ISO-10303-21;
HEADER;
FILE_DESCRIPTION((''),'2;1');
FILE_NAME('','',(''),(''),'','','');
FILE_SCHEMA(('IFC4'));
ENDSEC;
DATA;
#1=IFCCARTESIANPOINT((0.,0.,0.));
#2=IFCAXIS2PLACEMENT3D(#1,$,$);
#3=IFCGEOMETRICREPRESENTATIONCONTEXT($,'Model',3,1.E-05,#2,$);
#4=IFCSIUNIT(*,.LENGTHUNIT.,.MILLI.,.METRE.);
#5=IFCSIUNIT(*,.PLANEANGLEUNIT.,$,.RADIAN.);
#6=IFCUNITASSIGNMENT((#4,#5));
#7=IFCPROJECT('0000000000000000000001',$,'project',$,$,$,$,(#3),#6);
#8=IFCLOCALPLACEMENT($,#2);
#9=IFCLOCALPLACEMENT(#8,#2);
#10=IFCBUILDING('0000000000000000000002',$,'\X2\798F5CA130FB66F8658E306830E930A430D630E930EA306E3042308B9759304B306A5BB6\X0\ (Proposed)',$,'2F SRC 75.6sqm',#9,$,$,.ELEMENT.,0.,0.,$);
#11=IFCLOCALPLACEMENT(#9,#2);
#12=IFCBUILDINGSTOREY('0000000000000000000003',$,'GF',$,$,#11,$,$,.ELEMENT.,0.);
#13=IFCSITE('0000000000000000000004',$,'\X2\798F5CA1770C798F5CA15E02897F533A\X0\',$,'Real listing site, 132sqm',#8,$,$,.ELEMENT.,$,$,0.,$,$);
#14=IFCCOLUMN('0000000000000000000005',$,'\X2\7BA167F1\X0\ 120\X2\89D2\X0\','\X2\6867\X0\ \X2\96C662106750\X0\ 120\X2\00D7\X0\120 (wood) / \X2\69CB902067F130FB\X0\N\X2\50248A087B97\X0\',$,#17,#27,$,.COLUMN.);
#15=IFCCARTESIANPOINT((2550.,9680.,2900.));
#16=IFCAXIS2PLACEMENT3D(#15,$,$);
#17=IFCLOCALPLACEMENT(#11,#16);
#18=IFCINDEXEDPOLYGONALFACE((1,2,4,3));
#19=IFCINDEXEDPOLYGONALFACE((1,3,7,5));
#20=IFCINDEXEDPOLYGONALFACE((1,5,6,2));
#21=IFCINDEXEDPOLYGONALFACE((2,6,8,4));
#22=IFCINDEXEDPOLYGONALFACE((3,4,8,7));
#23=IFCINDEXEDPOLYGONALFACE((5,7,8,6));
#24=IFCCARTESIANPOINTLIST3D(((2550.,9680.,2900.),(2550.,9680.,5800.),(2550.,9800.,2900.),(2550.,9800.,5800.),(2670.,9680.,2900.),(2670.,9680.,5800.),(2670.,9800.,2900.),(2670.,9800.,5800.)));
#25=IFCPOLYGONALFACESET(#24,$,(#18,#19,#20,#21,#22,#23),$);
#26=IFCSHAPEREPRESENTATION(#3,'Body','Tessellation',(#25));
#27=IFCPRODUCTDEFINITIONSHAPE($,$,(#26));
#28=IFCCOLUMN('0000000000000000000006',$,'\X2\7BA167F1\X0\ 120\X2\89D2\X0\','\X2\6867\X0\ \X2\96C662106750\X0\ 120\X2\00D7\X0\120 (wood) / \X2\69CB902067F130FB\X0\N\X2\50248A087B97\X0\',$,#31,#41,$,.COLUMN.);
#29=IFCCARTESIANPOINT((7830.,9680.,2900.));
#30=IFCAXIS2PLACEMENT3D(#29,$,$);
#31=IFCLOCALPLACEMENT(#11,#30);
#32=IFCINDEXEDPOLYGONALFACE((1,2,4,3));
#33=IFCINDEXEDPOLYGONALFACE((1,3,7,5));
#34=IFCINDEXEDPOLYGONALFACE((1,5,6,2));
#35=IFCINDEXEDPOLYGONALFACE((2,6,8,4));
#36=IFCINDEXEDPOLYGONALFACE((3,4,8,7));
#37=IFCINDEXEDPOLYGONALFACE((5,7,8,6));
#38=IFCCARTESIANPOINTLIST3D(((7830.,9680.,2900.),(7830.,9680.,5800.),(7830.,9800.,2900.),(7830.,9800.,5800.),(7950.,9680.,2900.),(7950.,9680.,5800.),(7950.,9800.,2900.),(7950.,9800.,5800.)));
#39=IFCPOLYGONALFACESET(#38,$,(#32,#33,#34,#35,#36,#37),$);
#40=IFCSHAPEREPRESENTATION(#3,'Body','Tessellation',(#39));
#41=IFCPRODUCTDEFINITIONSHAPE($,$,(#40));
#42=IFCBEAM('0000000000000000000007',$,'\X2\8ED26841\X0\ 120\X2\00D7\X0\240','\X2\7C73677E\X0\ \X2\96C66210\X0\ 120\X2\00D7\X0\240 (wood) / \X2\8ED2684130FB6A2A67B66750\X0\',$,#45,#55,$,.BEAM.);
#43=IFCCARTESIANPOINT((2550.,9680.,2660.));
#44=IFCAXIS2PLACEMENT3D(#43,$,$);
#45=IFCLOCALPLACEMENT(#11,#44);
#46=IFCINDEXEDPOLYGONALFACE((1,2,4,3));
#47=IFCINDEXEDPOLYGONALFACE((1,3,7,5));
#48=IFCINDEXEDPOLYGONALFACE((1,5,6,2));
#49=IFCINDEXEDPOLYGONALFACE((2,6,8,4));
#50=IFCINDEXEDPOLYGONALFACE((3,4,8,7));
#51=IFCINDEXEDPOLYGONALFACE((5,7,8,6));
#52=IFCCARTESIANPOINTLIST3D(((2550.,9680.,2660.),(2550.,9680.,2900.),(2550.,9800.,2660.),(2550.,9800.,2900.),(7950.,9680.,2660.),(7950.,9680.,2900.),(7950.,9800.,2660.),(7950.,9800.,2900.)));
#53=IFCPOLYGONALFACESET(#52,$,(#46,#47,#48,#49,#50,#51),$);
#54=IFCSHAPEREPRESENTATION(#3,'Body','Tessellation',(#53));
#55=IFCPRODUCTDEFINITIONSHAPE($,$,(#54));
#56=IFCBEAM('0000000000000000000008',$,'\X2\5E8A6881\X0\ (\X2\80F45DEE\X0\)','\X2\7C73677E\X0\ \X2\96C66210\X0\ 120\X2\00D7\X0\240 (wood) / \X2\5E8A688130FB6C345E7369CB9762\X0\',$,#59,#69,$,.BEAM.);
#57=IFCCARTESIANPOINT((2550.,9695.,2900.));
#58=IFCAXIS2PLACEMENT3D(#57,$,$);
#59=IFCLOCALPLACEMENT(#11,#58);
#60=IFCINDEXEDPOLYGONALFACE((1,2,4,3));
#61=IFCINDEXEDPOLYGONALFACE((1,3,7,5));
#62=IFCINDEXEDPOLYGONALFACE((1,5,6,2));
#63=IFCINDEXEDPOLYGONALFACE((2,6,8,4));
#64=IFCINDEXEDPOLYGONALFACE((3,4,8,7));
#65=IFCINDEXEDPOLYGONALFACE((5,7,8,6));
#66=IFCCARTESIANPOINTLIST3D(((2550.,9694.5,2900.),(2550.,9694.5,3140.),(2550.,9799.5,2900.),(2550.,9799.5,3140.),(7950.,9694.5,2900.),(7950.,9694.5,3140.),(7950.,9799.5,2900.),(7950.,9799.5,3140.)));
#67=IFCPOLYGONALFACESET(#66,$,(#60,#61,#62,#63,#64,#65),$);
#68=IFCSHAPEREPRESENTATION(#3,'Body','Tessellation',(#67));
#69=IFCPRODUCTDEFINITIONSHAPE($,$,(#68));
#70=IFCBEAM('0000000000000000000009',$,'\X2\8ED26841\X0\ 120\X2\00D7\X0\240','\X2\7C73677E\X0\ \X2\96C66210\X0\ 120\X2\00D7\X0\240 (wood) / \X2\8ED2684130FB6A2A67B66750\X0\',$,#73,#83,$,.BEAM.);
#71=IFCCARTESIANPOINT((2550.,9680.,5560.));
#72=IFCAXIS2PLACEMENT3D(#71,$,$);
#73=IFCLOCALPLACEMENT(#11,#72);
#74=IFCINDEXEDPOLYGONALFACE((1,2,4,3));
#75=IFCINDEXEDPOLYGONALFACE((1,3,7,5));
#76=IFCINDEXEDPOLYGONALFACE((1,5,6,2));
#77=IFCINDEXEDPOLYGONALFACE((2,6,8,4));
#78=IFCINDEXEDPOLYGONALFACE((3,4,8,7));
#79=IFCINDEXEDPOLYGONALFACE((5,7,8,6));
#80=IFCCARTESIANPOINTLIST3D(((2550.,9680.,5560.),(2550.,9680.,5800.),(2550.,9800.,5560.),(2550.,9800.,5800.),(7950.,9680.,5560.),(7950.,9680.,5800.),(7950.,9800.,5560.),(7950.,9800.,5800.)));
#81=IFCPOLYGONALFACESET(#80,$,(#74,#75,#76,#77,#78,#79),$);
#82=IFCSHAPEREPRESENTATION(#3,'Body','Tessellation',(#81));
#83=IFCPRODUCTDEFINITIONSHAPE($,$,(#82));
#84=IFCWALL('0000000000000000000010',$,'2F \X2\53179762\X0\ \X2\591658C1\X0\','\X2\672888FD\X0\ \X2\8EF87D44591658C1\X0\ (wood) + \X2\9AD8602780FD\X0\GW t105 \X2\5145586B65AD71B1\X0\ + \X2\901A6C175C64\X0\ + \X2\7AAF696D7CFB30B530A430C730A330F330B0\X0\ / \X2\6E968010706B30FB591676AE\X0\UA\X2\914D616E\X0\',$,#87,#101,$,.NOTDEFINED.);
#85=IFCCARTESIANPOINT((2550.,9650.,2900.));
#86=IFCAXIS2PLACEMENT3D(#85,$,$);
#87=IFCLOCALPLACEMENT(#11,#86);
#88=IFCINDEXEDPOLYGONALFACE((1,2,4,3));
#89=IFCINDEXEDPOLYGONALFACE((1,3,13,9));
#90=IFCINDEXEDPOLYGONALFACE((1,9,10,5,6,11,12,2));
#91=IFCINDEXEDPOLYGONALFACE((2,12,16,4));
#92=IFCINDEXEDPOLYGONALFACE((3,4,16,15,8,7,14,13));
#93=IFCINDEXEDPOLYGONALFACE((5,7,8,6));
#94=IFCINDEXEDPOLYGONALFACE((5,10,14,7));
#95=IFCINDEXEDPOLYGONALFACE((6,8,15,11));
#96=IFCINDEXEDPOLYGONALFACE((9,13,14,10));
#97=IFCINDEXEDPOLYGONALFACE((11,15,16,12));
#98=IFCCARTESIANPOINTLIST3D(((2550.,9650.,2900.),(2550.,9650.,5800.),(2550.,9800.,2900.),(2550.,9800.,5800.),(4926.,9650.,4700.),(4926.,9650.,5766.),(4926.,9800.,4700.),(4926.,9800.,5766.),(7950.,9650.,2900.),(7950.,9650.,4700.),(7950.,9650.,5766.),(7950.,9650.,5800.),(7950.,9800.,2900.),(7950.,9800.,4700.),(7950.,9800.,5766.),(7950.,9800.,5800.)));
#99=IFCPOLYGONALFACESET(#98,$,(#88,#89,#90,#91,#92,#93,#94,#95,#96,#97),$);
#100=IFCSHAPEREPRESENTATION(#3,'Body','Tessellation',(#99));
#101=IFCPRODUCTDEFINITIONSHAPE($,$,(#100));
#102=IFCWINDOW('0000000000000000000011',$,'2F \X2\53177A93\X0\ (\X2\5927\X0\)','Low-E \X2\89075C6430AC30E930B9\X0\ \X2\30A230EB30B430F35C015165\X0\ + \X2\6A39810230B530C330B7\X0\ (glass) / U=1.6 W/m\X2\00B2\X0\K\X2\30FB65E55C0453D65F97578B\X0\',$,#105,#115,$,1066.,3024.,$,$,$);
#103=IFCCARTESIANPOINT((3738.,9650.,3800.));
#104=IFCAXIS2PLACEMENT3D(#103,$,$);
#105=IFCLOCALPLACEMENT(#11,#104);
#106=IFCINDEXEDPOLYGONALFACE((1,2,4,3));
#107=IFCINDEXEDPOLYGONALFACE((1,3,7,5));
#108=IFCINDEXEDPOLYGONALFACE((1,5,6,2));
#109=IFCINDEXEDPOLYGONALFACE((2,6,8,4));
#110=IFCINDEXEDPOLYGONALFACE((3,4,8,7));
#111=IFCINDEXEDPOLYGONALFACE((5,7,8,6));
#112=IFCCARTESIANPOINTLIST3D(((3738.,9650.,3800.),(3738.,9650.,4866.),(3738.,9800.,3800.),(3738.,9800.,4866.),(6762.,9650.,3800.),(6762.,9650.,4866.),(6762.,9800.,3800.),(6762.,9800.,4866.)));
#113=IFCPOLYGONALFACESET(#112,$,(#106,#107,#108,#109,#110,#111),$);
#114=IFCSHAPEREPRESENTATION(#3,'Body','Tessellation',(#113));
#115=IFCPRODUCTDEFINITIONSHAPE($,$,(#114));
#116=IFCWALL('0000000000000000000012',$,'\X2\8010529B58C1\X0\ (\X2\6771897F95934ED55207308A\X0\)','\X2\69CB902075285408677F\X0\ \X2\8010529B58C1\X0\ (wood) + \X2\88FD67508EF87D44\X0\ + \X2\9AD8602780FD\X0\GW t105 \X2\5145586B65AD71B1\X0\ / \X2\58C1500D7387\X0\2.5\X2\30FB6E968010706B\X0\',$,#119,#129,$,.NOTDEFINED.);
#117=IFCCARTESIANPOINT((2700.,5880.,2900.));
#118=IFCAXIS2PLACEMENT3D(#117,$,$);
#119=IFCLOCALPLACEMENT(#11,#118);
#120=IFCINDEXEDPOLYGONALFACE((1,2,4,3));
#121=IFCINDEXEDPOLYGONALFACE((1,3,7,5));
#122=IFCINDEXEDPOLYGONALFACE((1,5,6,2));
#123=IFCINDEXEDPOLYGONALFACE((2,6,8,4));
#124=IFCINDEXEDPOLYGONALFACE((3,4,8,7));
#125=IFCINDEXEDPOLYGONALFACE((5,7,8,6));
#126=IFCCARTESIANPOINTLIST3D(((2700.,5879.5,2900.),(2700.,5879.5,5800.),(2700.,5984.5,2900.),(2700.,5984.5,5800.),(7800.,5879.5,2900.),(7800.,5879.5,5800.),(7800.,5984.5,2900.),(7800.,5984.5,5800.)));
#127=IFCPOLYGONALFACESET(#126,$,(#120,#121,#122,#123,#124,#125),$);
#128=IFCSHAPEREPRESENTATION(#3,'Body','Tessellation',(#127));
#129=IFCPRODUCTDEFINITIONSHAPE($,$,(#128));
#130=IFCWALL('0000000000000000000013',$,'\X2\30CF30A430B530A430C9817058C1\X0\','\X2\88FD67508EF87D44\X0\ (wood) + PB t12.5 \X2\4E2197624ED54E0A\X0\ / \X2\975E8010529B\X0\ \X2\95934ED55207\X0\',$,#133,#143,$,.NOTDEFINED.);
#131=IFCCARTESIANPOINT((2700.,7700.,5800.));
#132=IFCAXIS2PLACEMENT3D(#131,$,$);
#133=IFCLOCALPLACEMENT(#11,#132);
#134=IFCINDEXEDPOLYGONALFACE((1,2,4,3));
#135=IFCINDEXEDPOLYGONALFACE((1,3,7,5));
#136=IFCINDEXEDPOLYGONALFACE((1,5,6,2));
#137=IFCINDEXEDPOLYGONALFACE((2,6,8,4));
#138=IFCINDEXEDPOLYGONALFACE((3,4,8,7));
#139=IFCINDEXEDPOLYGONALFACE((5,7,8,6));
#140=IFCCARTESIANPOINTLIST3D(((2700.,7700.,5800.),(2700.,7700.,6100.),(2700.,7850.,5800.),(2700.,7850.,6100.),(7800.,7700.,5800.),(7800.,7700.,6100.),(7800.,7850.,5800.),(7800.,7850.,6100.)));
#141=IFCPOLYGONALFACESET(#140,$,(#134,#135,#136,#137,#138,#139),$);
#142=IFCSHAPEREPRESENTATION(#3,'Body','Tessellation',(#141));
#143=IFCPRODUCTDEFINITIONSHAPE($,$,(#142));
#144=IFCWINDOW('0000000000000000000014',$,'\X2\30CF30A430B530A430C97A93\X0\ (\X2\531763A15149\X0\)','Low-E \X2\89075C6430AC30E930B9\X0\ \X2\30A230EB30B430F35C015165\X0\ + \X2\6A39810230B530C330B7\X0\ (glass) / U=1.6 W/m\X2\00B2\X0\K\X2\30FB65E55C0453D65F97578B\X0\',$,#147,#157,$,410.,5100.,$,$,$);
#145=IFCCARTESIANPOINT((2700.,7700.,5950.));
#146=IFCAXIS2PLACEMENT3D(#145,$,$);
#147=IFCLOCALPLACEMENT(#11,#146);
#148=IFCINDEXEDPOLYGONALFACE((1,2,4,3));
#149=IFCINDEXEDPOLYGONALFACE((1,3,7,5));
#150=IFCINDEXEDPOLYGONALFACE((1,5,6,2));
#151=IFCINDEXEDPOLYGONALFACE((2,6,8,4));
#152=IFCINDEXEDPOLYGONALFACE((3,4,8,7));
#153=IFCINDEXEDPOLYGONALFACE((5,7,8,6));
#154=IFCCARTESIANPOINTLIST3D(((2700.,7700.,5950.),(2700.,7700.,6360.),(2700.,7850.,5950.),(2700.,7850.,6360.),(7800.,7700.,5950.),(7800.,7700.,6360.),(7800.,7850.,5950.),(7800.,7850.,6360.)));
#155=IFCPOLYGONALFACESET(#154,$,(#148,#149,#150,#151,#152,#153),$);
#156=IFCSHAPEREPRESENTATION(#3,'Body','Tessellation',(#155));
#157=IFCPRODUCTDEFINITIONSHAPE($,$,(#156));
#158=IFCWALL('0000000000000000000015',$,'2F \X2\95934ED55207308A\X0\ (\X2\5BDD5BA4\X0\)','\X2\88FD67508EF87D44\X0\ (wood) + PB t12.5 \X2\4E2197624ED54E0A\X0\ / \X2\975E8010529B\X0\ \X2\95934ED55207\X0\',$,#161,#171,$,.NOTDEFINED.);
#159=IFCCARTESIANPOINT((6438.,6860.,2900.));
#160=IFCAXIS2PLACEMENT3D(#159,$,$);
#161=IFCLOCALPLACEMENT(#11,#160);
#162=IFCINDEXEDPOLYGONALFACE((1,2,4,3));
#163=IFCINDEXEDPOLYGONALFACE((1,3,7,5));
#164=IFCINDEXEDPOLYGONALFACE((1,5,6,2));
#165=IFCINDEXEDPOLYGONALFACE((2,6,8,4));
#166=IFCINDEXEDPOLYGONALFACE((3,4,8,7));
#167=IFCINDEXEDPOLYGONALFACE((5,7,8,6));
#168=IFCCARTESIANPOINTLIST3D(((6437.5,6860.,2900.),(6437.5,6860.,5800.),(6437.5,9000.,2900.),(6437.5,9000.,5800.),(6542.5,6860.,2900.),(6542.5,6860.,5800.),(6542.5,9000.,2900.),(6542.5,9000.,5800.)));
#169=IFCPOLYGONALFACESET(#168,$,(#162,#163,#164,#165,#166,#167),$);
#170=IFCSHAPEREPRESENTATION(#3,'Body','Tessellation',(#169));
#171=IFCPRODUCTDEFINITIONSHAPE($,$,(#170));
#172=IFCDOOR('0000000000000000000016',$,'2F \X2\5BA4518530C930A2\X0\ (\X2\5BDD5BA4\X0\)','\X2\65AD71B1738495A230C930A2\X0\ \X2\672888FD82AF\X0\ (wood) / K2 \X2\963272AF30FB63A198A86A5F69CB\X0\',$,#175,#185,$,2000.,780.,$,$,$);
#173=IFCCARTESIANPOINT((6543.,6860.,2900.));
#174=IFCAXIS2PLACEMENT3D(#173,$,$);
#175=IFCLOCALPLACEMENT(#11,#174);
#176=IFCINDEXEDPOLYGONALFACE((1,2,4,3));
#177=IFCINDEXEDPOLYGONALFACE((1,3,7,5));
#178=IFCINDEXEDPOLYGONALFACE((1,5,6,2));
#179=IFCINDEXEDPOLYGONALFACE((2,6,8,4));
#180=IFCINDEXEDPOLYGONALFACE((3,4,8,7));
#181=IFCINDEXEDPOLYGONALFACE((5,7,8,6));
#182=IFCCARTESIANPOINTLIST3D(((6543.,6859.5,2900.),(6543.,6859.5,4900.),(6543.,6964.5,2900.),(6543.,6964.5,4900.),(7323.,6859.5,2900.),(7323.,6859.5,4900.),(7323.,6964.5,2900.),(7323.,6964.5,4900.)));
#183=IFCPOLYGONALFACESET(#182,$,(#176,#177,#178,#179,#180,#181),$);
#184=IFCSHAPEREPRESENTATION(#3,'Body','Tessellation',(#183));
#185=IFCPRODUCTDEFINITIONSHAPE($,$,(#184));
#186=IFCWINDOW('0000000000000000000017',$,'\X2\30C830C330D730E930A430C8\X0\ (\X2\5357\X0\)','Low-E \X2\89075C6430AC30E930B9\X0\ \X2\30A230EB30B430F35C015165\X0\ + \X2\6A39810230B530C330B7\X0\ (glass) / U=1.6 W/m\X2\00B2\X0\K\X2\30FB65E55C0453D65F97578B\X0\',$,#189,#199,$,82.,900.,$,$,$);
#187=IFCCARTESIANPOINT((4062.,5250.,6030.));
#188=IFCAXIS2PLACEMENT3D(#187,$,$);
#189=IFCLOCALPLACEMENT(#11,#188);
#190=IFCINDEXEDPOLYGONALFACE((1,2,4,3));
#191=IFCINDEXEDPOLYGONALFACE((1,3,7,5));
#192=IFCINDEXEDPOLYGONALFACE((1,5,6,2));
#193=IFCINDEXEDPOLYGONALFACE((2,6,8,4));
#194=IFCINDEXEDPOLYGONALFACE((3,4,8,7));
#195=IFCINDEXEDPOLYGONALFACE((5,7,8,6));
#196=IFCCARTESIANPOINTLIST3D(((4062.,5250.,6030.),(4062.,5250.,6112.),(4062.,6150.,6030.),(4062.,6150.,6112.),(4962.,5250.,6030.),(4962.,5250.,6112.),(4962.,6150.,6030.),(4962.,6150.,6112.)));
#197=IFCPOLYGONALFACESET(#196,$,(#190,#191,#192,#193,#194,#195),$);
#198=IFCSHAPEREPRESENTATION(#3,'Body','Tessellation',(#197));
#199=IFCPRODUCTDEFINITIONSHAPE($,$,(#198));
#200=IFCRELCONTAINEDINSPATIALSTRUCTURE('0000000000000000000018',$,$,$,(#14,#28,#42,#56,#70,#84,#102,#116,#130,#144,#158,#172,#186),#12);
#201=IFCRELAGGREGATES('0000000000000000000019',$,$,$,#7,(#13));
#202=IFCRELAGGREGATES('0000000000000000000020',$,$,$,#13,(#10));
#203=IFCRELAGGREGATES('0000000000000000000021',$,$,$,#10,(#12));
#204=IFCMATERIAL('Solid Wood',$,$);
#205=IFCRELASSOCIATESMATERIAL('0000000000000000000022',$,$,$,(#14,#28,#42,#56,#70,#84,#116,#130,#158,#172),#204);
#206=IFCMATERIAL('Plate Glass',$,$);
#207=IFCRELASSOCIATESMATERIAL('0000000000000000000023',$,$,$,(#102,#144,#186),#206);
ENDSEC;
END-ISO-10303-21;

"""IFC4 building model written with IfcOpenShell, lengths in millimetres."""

from ifc_helpers import new_model, si_unit, frame, frame_2d, origin, place, context, project, spatial, rectangle, extrude, material, element, fill, save


model = new_model("IFC4")

# Units and contexts
model_context = context("Model", 3, precision=1e-05, world=origin())
ifc_project = project(units=[si_unit("LENGTHUNIT", "METRE", prefix="MILLI"), si_unit("PLANEANGLEUNIT", "RADIAN")], contexts=[model_context])

# Site, building, storey
site_placement = place(None, origin())
site = spatial("IfcSite", under=ifc_project, at=site_placement, Name="福岡県福岡市西区", ObjectType="Real listing site, 132sqm", CompositionType="ELEMENT", RefElevation=0.0)
building_placement = place(site_placement, origin())
building = spatial("IfcBuilding", under=site, at=building_placement, Name="福岡・書斎とライブラリのある静かな家 (Proposed)", ObjectType="2F SRC 75.6sqm", CompositionType="ELEMENT", ElevationOfRefHeight=0.0, ElevationOfTerrain=0.0)
storey_placement = place(building_placement, origin())
storey = spatial("IfcBuildingStorey", under=building, at=storey_placement, Name="GF", CompositionType="ELEMENT", Elevation=0.0)

# Columns
ifc_material_1 = material(Name="Solid Wood")
column_1_placement = place(storey_placement, frame((2550.0, 9680.0, 2900.0)))
element("IfcColumn", 1, at=column_1_placement, inside=storey, material=ifc_material_1, Name="管柱 120角", Description="桧 集成材 120×120 (wood) / 構造柱・N値計算", PredefinedType="COLUMN", context=model_context, shape_type="SweptSolid", body=[
    extrude(rectangle(XDim=120.0, YDim=120.0, at=frame_2d((60.0, 60.0))), frame((2550.0, 9680.0, 2900.0)), (0.0, 0.0, 1.0), 2900.0),
])
column_2_placement = place(storey_placement, frame((7830.0, 9680.0, 2900.0)))
element("IfcColumn", 2, at=column_2_placement, inside=storey, material=ifc_material_1, Name="管柱 120角", Description="桧 集成材 120×120 (wood) / 構造柱・N値計算", PredefinedType="COLUMN", context=model_context, shape_type="SweptSolid", body=[
    extrude(rectangle(XDim=120.0, YDim=120.0, at=frame_2d((60.0, 60.0))), frame((7830.0, 9680.0, 2900.0)), (0.0, 0.0, 1.0), 2900.0),
])

# Beams
beam_1_placement = place(storey_placement, frame((2550.0, 9680.0, 2660.0)))
element("IfcBeam", 3, at=beam_1_placement, inside=storey, material=ifc_material_1, Name="軒桁 120×240", Description="米松 集成 120×240 (wood) / 軒桁・横架材", PredefinedType="BEAM", context=model_context, shape_type="SweptSolid", body=[
    extrude(rectangle(XDim=5400.0, YDim=120.0, at=frame_2d((2700.0, 60.0))), frame((2550.0, 9680.0, 2660.0)), (0.0, 0.0, 1.0), 240.0),
])
beam_2_placement = place(storey_placement, frame((2550.0, 9695.0, 2900.0)))
element("IfcBeam", 4, at=beam_2_placement, inside=storey, material=ifc_material_1, Name="床梁 (胴差)", Description="米松 集成 120×240 (wood) / 床梁・水平構面", PredefinedType="BEAM", context=model_context, shape_type="SweptSolid", body=[
    extrude(rectangle(XDim=5400.0, YDim=105.0, at=frame_2d((2700.0, 52.0))), frame((2550.0, 9695.0, 2900.0)), (0.0, 0.0, 1.0), 240.0),
])
beam_3_placement = place(storey_placement, frame((2550.0, 9680.0, 5560.0)))
element("IfcBeam", 5, at=beam_3_placement, inside=storey, material=ifc_material_1, Name="軒桁 120×240", Description="米松 集成 120×240 (wood) / 軒桁・横架材", PredefinedType="BEAM", context=model_context, shape_type="SweptSolid", body=[
    extrude(rectangle(XDim=5400.0, YDim=120.0, at=frame_2d((2700.0, 60.0))), frame((2550.0, 9680.0, 5560.0)), (0.0, 0.0, 1.0), 240.0),
])

# Wall, opening, window
wall_1_placement = place(storey_placement, frame((2550.0, 9650.0, 2900.0)))
wall_1 = element("IfcWall", 6, at=wall_1_placement, inside=storey, material=ifc_material_1, Name="2F 北面 外壁", Description="木製 軸組外壁 (wood) + 高性能GW t105 充填断熱 + 通気層 + 窯業系サイディング / 準耐火・外皮UA配慮", PredefinedType="NOTDEFINED", context=model_context, shape_type="SweptSolid", body=[
    extrude(rectangle(XDim=5400.0, YDim=150.0, at=frame_2d((2700.0, 75.0))), frame((2550.0, 9650.0, 2900.0)), (0.0, 0.0, 1.0), 2900.0),
])
opening_1_placement = place(storey_placement, frame((3738.0, 9650.0, 3800.0)))
opening_1 = element("IfcOpeningElement", 7, at=opening_1_placement, cuts=wall_1, PredefinedType="NOTDEFINED", context=model_context, shape_type="SweptSolid", body=[
    extrude(rectangle(XDim=3024.0, YDim=150.0, at=frame_2d((1512.0, 75.0))), frame((3738.0, 9650.0, 3800.0)), (0.0, 0.0, 1.0), 1066.0),
])
ifc_material_2 = material(Name="Plate Glass")
window_1_placement = place(storey_placement, frame((3738.0, 9650.0, 3800.0)))
window_1 = element("IfcWindow", 8, at=window_1_placement, inside=storey, material=ifc_material_2, Name="2F 北窓 (大)", Description="Low-E 複層ガラス アルゴン封入 + 樹脂サッシ (glass) / U=1.6 W/m²K・日射取得型", OverallHeight=1066.0, OverallWidth=3024.0, context=model_context, shape_type="SweptSolid", body=[
    extrude(rectangle(XDim=3024.0, YDim=150.0, at=frame_2d((1512.0, 75.0))), frame((3738.0, 9650.0, 3800.0)), (0.0, 0.0, 1.0), 1066.0),
])
fill(opening_1, window_1)

# Wall
wall_2_placement = place(storey_placement, frame((2700.0, 5880.0, 2900.0)))
element("IfcWall", 9, at=wall_2_placement, inside=storey, material=ifc_material_1, Name="耐力壁 (東西間仕切り)", Description="構造用合板 耐力壁 (wood) + 製材軸組 + 高性能GW t105 充填断熱 / 壁倍率2.5・準耐火", PredefinedType="NOTDEFINED", context=model_context, shape_type="SweptSolid", body=[
    extrude(rectangle(XDim=5100.0, YDim=105.0, at=frame_2d((2550.0, 52.0))), frame((2700.0, 5880.0, 2900.0)), (0.0, 0.0, 1.0), 2900.0),
])

# Wall, opening, window
wall_3_placement = place(storey_placement, frame((2700.0, 7700.0, 5800.0)))
wall_3 = element("IfcWall", 10, at=wall_3_placement, inside=storey, material=ifc_material_1, Name="ハイサイド腰壁", Description="製材軸組 (wood) + PB t12.5 両面仕上 / 非耐力 間仕切", PredefinedType="NOTDEFINED", context=model_context, shape_type="SweptSolid", body=[
    extrude(rectangle(XDim=5100.0, YDim=150.0, at=frame_2d((2550.0, 75.0))), frame((2700.0, 7700.0, 5800.0)), (0.0, 0.0, 1.0), 700.0),
])
opening_2_placement = place(storey_placement, frame((2700.0, 7700.0, 5950.0)))
opening_2 = element("IfcOpeningElement", 11, at=opening_2_placement, cuts=wall_3, PredefinedType="NOTDEFINED", context=model_context, shape_type="SweptSolid", body=[
    extrude(rectangle(XDim=5100.0, YDim=150.0, at=frame_2d((2550.0, 75.0))), frame((2700.0, 7700.0, 5950.0)), (0.0, 0.0, 1.0), 410.0),
])
window_2_placement = place(storey_placement, frame((2700.0, 7700.0, 5950.0)))
window_2 = element("IfcWindow", 12, at=window_2_placement, inside=storey, material=ifc_material_2, Name="ハイサイド窓 (北採光)", Description="Low-E 複層ガラス アルゴン封入 + 樹脂サッシ (glass) / U=1.6 W/m²K・日射取得型", OverallHeight=410.0, OverallWidth=5100.0, context=model_context, shape_type="SweptSolid", body=[
    extrude(rectangle(XDim=5100.0, YDim=150.0, at=frame_2d((2550.0, 75.0))), frame((2700.0, 7700.0, 5950.0)), (0.0, 0.0, 1.0), 410.0),
])
fill(opening_2, window_2)

# Wall
wall_4_placement = place(storey_placement, frame((6438.0, 6860.0, 2900.0)))
element("IfcWall", 13, at=wall_4_placement, inside=storey, material=ifc_material_1, Name="2F 間仕切り (寝室)", Description="製材軸組 (wood) + PB t12.5 両面仕上 / 非耐力 間仕切", PredefinedType="NOTDEFINED", context=model_context, shape_type="SweptSolid", body=[
    extrude(rectangle(XDim=105.0, YDim=2140.0, at=frame_2d((52.0, 1070.0))), frame((6438.0, 6860.0, 2900.0)), (0.0, 0.0, 1.0), 2900.0),
])

# Door
door_placement = place(storey_placement, frame((6543.0, 6860.0, 2900.0)))
element("IfcDoor", 14, at=door_placement, inside=storey, material=ifc_material_1, Name="2F 室内ドア (寝室)", Description="断熱玄関ドア 木製芯 (wood) / K2 防犯・採風機構", OverallHeight=2000.0, OverallWidth=780.0, context=model_context, shape_type="SweptSolid", body=[
    extrude(rectangle(XDim=780.0, YDim=105.0, at=frame_2d((390.0, 52.0))), frame((6543.0, 6860.0, 2900.0)), (0.0, 0.0, 1.0), 2000.0),
])

# Window
window_3_placement = place(storey_placement, frame((4062.0, 5250.0, 6030.0)))
element("IfcWindow", 15, at=window_3_placement, inside=storey, material=ifc_material_2, Name="トップライト (南)", Description="Low-E 複層ガラス アルゴン封入 + 樹脂サッシ (glass) / U=1.6 W/m²K・日射取得型", OverallHeight=82.0, OverallWidth=900.0, context=model_context, shape_type="SweptSolid", body=[
    extrude(rectangle(XDim=900.0, YDim=900.0, at=frame_2d((450.0, 450.0))), frame((4062.0, 5250.0, 6030.0)), (0.0, 0.0, 1.0), 82.0),
])

save(model, "model.ifc")
